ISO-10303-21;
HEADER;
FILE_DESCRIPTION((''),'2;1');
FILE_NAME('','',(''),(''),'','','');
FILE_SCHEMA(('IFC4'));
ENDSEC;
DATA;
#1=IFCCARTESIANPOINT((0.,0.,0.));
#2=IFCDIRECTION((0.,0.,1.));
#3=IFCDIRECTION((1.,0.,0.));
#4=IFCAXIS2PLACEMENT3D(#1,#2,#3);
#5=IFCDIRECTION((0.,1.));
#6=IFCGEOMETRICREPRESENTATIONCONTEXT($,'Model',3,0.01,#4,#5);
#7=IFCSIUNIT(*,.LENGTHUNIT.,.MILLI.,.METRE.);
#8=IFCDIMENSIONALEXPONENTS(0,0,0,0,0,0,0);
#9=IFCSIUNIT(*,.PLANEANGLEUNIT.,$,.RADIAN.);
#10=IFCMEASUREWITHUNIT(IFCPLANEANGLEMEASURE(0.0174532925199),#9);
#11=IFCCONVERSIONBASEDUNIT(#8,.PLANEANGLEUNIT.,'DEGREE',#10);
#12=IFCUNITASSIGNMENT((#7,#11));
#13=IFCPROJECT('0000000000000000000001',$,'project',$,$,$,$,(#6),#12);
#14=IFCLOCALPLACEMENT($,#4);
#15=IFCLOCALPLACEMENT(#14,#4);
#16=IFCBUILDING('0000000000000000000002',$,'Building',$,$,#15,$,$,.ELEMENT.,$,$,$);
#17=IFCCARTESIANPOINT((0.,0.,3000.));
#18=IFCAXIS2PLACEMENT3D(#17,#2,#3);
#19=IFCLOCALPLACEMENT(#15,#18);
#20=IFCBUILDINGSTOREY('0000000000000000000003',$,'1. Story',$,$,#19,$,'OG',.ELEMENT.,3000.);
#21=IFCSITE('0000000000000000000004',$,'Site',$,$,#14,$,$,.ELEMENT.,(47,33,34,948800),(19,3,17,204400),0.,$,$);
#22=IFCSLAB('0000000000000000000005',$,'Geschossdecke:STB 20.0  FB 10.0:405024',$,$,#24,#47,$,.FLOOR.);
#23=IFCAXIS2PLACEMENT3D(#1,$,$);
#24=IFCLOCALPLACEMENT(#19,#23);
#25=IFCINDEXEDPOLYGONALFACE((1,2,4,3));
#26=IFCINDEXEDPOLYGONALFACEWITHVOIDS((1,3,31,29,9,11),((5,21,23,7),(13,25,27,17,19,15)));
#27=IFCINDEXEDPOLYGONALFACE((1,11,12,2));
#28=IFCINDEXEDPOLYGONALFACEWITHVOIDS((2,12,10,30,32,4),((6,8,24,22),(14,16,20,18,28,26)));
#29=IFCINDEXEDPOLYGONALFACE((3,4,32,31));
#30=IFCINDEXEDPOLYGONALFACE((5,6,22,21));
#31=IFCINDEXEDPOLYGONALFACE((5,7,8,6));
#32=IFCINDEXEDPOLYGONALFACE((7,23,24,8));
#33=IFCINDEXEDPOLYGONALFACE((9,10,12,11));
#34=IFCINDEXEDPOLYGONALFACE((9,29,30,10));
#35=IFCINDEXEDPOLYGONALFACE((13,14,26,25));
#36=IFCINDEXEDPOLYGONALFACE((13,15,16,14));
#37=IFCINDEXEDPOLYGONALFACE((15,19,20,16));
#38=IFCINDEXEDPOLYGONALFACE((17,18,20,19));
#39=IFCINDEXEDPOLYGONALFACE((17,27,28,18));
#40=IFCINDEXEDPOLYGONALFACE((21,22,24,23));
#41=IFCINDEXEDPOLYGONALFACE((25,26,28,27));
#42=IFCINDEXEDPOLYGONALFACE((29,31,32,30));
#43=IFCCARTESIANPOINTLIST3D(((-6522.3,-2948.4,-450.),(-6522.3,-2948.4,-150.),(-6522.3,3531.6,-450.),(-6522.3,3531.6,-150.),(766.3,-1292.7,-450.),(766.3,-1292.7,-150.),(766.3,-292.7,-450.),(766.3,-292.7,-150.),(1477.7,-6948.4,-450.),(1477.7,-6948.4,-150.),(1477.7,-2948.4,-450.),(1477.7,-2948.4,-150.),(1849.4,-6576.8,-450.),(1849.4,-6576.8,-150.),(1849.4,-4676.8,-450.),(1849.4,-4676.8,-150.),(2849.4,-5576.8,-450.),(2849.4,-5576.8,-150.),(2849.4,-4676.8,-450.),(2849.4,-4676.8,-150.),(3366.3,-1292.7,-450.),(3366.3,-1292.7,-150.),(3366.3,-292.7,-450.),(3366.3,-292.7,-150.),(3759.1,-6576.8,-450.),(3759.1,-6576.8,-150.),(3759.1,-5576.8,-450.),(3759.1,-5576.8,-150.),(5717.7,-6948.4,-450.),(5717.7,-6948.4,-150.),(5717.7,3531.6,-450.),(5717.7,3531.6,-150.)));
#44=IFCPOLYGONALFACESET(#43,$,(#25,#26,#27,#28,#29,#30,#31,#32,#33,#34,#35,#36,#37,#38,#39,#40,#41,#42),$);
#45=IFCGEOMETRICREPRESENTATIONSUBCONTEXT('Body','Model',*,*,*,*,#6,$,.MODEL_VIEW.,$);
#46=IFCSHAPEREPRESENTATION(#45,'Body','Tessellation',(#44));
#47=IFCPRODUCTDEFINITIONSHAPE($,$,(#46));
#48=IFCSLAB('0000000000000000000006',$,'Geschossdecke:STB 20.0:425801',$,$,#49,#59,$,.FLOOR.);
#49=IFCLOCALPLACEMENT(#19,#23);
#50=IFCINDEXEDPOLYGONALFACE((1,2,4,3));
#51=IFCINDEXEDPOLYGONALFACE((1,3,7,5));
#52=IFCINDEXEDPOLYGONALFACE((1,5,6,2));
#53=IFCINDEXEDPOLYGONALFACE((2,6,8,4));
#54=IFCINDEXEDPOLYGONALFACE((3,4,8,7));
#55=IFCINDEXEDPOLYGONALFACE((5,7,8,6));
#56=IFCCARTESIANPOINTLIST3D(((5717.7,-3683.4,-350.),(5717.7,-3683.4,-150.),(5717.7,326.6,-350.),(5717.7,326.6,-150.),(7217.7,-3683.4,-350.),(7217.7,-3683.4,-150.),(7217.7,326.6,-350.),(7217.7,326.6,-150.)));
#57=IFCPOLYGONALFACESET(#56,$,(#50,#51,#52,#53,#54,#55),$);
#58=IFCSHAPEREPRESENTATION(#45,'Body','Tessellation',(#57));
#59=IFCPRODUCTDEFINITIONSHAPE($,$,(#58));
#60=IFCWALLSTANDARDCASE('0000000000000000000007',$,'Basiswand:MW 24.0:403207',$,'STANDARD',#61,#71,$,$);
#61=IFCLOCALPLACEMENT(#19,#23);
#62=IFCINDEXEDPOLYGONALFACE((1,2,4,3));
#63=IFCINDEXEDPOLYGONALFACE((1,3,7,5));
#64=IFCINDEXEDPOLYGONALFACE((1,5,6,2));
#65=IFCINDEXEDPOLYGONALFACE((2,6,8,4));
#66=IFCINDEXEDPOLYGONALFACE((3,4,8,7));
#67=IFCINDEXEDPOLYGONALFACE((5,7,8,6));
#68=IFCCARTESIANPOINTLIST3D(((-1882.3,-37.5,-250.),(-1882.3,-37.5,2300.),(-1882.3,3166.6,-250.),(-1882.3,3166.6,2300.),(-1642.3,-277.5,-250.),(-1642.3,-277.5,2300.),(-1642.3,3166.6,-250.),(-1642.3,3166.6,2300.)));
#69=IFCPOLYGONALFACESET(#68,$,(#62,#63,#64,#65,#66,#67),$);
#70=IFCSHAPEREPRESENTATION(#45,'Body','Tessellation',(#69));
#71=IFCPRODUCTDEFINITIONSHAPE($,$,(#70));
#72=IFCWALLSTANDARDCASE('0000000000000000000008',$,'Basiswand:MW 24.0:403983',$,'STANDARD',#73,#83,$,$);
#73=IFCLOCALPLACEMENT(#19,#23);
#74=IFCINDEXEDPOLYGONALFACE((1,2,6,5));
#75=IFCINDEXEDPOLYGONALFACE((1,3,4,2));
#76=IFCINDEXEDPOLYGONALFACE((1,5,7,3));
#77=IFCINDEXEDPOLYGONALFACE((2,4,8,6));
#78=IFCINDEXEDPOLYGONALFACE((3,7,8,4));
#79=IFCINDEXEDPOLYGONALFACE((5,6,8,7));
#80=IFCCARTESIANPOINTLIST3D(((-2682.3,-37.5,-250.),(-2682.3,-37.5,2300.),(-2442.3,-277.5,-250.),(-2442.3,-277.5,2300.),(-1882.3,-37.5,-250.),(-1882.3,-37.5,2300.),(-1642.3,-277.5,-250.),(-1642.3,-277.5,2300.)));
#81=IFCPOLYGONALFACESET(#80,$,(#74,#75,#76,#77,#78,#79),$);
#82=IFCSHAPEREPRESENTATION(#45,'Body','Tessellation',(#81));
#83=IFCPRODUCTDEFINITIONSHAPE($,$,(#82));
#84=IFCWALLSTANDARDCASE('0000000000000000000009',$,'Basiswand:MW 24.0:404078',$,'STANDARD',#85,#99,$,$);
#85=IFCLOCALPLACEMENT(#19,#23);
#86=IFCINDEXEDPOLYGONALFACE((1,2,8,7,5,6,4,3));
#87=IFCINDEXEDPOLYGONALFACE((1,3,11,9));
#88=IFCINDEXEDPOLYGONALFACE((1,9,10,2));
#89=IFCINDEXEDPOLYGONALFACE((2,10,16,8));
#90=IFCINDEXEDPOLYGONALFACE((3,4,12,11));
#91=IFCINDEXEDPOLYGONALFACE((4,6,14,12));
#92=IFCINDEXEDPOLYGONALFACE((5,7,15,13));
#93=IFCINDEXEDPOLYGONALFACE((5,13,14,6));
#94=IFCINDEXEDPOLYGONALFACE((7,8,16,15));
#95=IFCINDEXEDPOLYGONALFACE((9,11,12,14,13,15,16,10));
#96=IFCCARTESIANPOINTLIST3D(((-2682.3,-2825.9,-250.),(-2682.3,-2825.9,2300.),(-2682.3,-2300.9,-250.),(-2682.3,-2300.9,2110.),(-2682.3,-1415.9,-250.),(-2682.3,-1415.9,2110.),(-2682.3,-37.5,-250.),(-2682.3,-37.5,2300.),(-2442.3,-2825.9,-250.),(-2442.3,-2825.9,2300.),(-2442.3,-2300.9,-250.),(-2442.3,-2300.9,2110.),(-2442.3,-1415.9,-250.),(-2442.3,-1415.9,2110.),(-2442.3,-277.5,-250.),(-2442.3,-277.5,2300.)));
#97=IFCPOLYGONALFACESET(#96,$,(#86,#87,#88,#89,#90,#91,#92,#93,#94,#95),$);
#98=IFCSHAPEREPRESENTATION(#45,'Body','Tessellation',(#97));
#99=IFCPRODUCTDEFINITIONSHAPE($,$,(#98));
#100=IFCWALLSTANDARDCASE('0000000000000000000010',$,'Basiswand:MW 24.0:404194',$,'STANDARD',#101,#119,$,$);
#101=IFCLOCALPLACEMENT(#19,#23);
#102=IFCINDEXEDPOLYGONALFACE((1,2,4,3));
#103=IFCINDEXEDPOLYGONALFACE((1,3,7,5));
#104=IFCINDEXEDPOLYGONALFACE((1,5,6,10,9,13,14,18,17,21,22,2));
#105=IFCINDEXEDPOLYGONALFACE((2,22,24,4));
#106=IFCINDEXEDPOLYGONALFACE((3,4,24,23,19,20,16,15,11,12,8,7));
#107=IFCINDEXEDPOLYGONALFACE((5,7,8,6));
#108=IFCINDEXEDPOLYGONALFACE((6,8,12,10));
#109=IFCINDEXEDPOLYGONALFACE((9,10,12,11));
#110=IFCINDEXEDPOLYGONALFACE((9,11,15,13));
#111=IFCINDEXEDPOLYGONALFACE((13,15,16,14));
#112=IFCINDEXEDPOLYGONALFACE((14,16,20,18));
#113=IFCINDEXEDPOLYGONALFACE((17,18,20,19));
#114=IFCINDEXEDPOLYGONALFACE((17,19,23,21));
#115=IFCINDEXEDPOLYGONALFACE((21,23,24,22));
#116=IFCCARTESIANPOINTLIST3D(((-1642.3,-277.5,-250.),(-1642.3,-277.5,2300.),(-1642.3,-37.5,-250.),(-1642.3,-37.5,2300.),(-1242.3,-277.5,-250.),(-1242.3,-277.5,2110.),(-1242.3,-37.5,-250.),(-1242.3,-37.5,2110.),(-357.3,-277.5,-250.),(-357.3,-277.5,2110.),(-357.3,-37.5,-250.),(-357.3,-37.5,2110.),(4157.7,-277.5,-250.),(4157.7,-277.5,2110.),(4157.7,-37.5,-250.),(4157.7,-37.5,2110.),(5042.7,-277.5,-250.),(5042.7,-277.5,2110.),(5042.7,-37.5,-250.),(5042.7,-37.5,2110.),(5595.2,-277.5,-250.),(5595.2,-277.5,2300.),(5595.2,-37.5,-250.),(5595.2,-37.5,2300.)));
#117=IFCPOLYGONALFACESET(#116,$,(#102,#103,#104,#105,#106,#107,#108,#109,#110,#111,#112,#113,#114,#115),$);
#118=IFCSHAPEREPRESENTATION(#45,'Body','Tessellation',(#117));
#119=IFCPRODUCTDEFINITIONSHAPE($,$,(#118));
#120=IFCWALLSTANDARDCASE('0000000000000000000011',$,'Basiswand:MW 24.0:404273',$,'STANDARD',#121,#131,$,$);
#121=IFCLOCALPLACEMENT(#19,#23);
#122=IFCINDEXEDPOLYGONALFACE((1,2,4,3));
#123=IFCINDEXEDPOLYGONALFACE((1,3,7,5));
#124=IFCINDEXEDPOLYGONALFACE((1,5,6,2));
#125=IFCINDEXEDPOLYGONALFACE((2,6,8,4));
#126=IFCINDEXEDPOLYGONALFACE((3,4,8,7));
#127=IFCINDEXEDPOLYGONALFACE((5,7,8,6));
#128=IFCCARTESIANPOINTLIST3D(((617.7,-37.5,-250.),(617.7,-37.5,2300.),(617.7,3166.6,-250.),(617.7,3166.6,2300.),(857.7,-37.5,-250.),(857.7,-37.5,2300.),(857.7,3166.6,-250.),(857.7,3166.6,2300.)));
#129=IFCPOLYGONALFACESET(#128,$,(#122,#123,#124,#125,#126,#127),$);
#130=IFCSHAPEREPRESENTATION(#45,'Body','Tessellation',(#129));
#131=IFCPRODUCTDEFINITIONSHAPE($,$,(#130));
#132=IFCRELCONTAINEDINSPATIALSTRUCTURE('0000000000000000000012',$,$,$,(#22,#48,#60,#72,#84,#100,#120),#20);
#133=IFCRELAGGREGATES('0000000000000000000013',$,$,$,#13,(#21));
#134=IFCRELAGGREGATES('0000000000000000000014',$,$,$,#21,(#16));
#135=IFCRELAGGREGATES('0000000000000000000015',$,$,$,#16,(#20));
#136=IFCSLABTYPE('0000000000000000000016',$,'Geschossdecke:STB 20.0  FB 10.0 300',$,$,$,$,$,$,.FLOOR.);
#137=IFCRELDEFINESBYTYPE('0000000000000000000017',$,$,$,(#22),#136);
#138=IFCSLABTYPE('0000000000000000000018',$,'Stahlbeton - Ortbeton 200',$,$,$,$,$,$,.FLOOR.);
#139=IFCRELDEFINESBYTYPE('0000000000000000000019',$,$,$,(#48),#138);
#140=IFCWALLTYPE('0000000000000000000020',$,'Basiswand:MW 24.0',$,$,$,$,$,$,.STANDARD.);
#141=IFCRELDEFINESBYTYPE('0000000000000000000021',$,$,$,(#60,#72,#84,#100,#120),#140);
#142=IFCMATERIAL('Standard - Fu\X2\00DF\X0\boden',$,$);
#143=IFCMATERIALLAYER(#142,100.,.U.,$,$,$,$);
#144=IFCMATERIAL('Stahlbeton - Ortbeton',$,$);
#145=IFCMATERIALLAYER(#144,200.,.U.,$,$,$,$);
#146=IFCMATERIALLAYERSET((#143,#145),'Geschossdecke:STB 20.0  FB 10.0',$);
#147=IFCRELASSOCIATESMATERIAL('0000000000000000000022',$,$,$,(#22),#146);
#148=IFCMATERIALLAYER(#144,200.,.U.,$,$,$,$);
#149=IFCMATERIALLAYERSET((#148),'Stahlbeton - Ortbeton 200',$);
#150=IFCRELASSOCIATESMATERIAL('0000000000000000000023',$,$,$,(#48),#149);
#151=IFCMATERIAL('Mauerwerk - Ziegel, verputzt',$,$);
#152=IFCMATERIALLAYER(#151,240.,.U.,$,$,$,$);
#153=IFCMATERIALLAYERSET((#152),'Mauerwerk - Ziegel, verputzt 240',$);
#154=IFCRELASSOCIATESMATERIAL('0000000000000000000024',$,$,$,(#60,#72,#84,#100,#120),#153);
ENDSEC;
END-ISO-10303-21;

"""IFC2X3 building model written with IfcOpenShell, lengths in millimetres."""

from ifc_helpers import new_model, entity, si_unit, converted_unit, direction, frame, origin_with_axes, origin_2d_with_axis, place, context, subcontext, project, spatial, polyline, rectangle, outline, extrude, material, layer, layer_set, layer_usage, type_object, element, save


model = new_model("IFC2X3")

# Units and contexts
model_context = context("Model", 3, precision=0.01, world=origin_with_axes(), true_north=direction((0.0, 1.0)))
body_context = subcontext(model_context, "Body", "Model", "MODEL_VIEW")
ifc_project = project(units=[si_unit("LENGTHUNIT", "METRE", prefix="MILLI"), converted_unit("PLANEANGLEUNIT", "DEGREE", entity("IfcPlaneAngleMeasure", 0.0174532925199), si_unit("PLANEANGLEUNIT", "RADIAN"), dimensions=[0, 0, 0, 0, 0, 0, 0])], contexts=[model_context])

# Site, building, storey
site_placement = place(None, origin_with_axes())
site = spatial("IfcSite", under=ifc_project, at=site_placement, Name="Site", CompositionType="ELEMENT", RefLatitude=(47, 33, 34, 948800), RefLongitude=(19, 3, 17, 204400), RefElevation=0.0)
building_placement = place(site_placement, origin_with_axes())
building = spatial("IfcBuilding", under=site, at=building_placement, Name="Building", CompositionType="ELEMENT")
storey_placement = place(building_placement, frame((0.0, 0.0, 3000.0), z_axis=(0.0, 0.0, 1.0), x_axis=(1.0, 0.0, 0.0)))
storey = spatial("IfcBuildingStorey", under=building, at=storey_placement, Name="1. Story", LongName="OG", CompositionType="ELEMENT", Elevation=3000.0)

# Slab, openings
ifc_material_1 = material(Name="Standard - Fußboden")
ifc_layer_1 = layer(ifc_material_1, 100.0, ventilated="UNKNOWN")
ifc_material_2 = material(Name="Stahlbeton - Ortbeton")
ifc_layer_2 = layer(ifc_material_2, 200.0, ventilated="UNKNOWN")
ifc_layer_set_1 = layer_set([ifc_layer_1, ifc_layer_2], Name="Geschossdecke:STB 20.0  FB 10.0")
ifc_layer_usage_1 = layer_usage(ifc_layer_set_1, "AXIS3", "NEGATIVE", 300.0)
slab_type_1 = type_object("IfcSlabType", Name="Geschossdecke:STB 20.0  FB 10.0 300", PredefinedType="FLOOR")
slab_1_placement = place(storey_placement, frame((-6522.3, 3531.6, -450.0), z_axis=(0.0, 0.0, 1.0), x_axis=(1.0, 0.0, 0.0)))
slab_1 = element("IfcSlab", 1, at=slab_1_placement, inside=storey, type_object=slab_type_1, material=ifc_layer_usage_1, Name="Geschossdecke:STB 20.0  FB 10.0:405024", PredefinedType="FLOOR", context=body_context, shape_type="SweptSolid", body=[
    extrude(outline(polyline([(0.0, 0.0), (0.0, -6480.0), (8000.0, -6480.0), (8000.0, -10480.0), (12240.0, -10480.0), (12240.0, 0.0), (0.0, 0.0)])), origin_with_axes(), (0.0, 0.0, 1.0), 300.0),
])
opening_1_placement = place(slab_1_placement, frame((8371.7, -8208.3, 0.0), z_axis=(0.0, 0.0, 1.0), x_axis=(0.0, -1.0, 0.0)))
element("IfcOpeningElement", 2, at=opening_1_placement, cuts=slab_1, context=body_context, shape_type="SweptSolid", body=[
    extrude(outline(polyline([(0.0, 0.0), (1900.0, 0.0), (1900.0, 1909.7), (900.0, 1909.7), (900.0, 1000.0), (0.0, 1000.0), (0.0, 0.0)])), origin_with_axes(), (0.0, 0.0, 1.0), 300.0),
])
opening_2_placement = place(slab_1_placement, frame((6522.3, -3531.6, -2550.0), z_axis=(0.0, 0.0, 1.0), x_axis=(1.0, 0.0, 0.0)))
element("IfcOpeningElement", 3, at=opening_2_placement, cuts=slab_1, ObjectType="OPENING", context=body_context, shape_type="SweptSolid", body=[
    extrude(rectangle(XDim=2600.0, YDim=1000.0, at=origin_2d_with_axis()), frame((2066.3, -792.7, 2850.0), z_axis=(0.0, 0.0, -1.0), x_axis=(1.0, 0.0, 0.0)), (0.0, 0.0, 1.0), 300.0),
])

# Slab
ifc_layer_3 = layer(ifc_material_2, 200.0, ventilated="UNKNOWN")
ifc_layer_set_2 = layer_set([ifc_layer_3], Name="Stahlbeton - Ortbeton 200")
ifc_layer_usage_2 = layer_usage(ifc_layer_set_2, "AXIS3", "NEGATIVE", 200.0)
slab_type_2 = type_object("IfcSlabType", Name="Stahlbeton - Ortbeton 200", PredefinedType="FLOOR")
slab_2_placement = place(storey_placement, frame((7217.7, 326.6, -150.0), z_axis=(0.0, 0.0, 1.0), x_axis=(1.0, 0.0, 0.0)))
element("IfcSlab", 4, at=slab_2_placement, inside=storey, type_object=slab_type_2, material=ifc_layer_usage_2, Name="Geschossdecke:STB 20.0:425801", PredefinedType="FLOOR", context=body_context, shape_type="SweptSolid", body=[
    extrude(outline(polyline([(0.0, 0.0), (-1500.0, 0.0), (-1500.0, -4010.0), (0.0, -4010.0), (0.0, 0.0)])), frame((0.0, 0.0, -200.0), z_axis=(0.0, 0.0, 1.0), x_axis=(1.0, 0.0, 0.0)), (0.0, 0.0, 1.0), 200.0),
])

# Walls
ifc_material_3 = material(Name="Mauerwerk - Ziegel, verputzt")
ifc_layer_4 = layer(ifc_material_3, 240.0, ventilated="UNKNOWN")
ifc_layer_set_3 = layer_set([ifc_layer_4], Name="Mauerwerk - Ziegel, verputzt 240")
ifc_layer_usage_3 = layer_usage(ifc_layer_set_3, "AXIS2", "POSITIVE", -120.0)
wall_type = type_object("IfcWallType", Name="Basiswand:MW 24.0", PredefinedType="STANDARD")
wall_1_placement = place(storey_placement, frame((-1762.3, 3166.6, -250.0), z_axis=(0.0, 0.0, 1.0), x_axis=(0.0, -1.0, 0.0)))
element("IfcWallStandardCase", 5, at=wall_1_placement, inside=storey, type_object=wall_type, material=ifc_layer_usage_3, Name="Basiswand:MW 24.0:403207", ObjectType="STANDARD", context=body_context, shape_type="SweptSolid", body=[
    extrude(outline(polyline([(0.0, -120.0), (3204.1, -120.0), (3444.1, 120.0), (0.0, 120.0), (0.0, -120.0)])), origin_with_axes(), (0.0, 0.0, 1.0), 2550.0),
])
ifc_layer_usage_4 = layer_usage(ifc_layer_set_3, "AXIS2", "POSITIVE", -120.0)
wall_2_placement = place(storey_placement, frame((-1762.3, -157.5, -250.0), z_axis=(0.0, 0.0, 1.0), x_axis=(-1.0, 0.0, 0.0)))
element("IfcWallStandardCase", 6, at=wall_2_placement, inside=storey, type_object=wall_type, material=ifc_layer_usage_4, Name="Basiswand:MW 24.0:403983", ObjectType="STANDARD", context=body_context, shape_type="SweptSolid", body=[
    extrude(outline(polyline([(120.0, -120.0), (920.0, -120.0), (680.0, 120.0), (-120.0, 120.0), (120.0, -120.0)])), origin_with_axes(), (0.0, 0.0, 1.0), 2550.0),
])

# Wall, opening
ifc_layer_usage_5 = layer_usage(ifc_layer_set_3, "AXIS2", "POSITIVE", -120.0)
wall_3_placement = place(storey_placement, frame((-2562.3, -157.5, -250.0), z_axis=(0.0, 0.0, 1.0), x_axis=(0.0, -1.0, 0.0)))
wall_3 = element("IfcWallStandardCase", 7, at=wall_3_placement, inside=storey, type_object=wall_type, material=ifc_layer_usage_5, Name="Basiswand:MW 24.0:404078", ObjectType="STANDARD", context=body_context, shape_type="SweptSolid", body=[
    extrude(outline(polyline([(-120.0, -120.0), (2668.4, -120.0), (2668.4, 120.0), (120.0, 120.0), (-120.0, -120.0)])), origin_with_axes(), (0.0, 0.0, 1.0), 2550.0),
])
opening_3_placement = place(wall_3_placement, frame((1700.9, 0.0, 0.0), z_axis=(0.0, 0.0, 1.0), x_axis=(1.0, 0.0, 0.0)))
element("IfcOpeningElement", 8, at=opening_3_placement, cuts=wall_3, context=body_context, shape_type="SweptSolid", body=[
    extrude(outline(polyline([(-442.5, -2360.0), (442.5, -2360.0), (442.5, 0.0), (-442.5, 0.0), (-442.5, -2360.0)])), frame((0.0, 120.0, 0.0), z_axis=(0.0, -1.0, 0.0), x_axis=(-1.0, 0.0, 0.0)), (0.0, 0.0, 1.0), 240.0),
])

# Wall, openings
ifc_layer_usage_6 = layer_usage(ifc_layer_set_3, "AXIS2", "POSITIVE", -120.0)
wall_4_placement = place(storey_placement, frame((-1762.3, -157.5, -250.0), z_axis=(0.0, 0.0, 1.0), x_axis=(1.0, 0.0, 0.0)))
wall_4 = element("IfcWallStandardCase", 9, at=wall_4_placement, inside=storey, type_object=wall_type, material=ifc_layer_usage_6, Name="Basiswand:MW 24.0:404194", ObjectType="STANDARD", context=body_context, shape_type="SweptSolid", body=[
    extrude(outline(polyline([(120.0, -120.0), (7357.5, -120.0), (7357.5, 120.0), (120.0, 120.0), (120.0, -120.0)])), origin_with_axes(), (0.0, 0.0, 1.0), 2550.0),
])
opening_4_placement = place(wall_4_placement, frame((6362.5, 0.0, 0.0), z_axis=(0.0, 0.0, 1.0), x_axis=(1.0, 0.0, 0.0)))
element("IfcOpeningElement", 10, at=opening_4_placement, cuts=wall_4, context=body_context, shape_type="SweptSolid", body=[
    extrude(outline(polyline([(-442.5, -2360.0), (442.5, -2360.0), (442.5, 0.0), (-442.5, 0.0), (-442.5, -2360.0)])), frame((0.0, -120.0, 0.0), z_axis=(0.0, 1.0, 0.0), x_axis=(1.0, 0.0, 0.0)), (0.0, 0.0, 1.0), 240.0),
])
opening_5_placement = place(wall_4_placement, frame((962.5, 0.0, 0.0), z_axis=(0.0, 0.0, 1.0), x_axis=(1.0, 0.0, 0.0)))
element("IfcOpeningElement", 11, at=opening_5_placement, cuts=wall_4, context=body_context, shape_type="SweptSolid", body=[
    extrude(outline(polyline([(-442.5, -2360.0), (442.5, -2360.0), (442.5, 0.0), (-442.5, 0.0), (-442.5, -2360.0)])), frame((0.0, -120.0, 0.0), z_axis=(0.0, 1.0, 0.0), x_axis=(1.0, 0.0, 0.0)), (0.0, 0.0, 1.0), 240.0),
])

# Wall
ifc_layer_usage_7 = layer_usage(ifc_layer_set_3, "AXIS2", "POSITIVE", -120.0)
wall_5_placement = place(storey_placement, frame((737.7, 3166.6, -250.0), z_axis=(0.0, 0.0, 1.0), x_axis=(0.0, -1.0, 0.0)))
element("IfcWallStandardCase", 12, at=wall_5_placement, inside=storey, type_object=wall_type, material=ifc_layer_usage_7, Name="Basiswand:MW 24.0:404273", ObjectType="STANDARD", context=body_context, shape_type="SweptSolid", body=[
    extrude(outline(polyline([(0.0, -120.0), (3204.1, -120.0), (3204.1, 120.0), (0.0, 120.0), (0.0, -120.0)])), origin_with_axes(), (0.0, 0.0, 1.0), 2550.0),
])

save(model, "model.ifc")
